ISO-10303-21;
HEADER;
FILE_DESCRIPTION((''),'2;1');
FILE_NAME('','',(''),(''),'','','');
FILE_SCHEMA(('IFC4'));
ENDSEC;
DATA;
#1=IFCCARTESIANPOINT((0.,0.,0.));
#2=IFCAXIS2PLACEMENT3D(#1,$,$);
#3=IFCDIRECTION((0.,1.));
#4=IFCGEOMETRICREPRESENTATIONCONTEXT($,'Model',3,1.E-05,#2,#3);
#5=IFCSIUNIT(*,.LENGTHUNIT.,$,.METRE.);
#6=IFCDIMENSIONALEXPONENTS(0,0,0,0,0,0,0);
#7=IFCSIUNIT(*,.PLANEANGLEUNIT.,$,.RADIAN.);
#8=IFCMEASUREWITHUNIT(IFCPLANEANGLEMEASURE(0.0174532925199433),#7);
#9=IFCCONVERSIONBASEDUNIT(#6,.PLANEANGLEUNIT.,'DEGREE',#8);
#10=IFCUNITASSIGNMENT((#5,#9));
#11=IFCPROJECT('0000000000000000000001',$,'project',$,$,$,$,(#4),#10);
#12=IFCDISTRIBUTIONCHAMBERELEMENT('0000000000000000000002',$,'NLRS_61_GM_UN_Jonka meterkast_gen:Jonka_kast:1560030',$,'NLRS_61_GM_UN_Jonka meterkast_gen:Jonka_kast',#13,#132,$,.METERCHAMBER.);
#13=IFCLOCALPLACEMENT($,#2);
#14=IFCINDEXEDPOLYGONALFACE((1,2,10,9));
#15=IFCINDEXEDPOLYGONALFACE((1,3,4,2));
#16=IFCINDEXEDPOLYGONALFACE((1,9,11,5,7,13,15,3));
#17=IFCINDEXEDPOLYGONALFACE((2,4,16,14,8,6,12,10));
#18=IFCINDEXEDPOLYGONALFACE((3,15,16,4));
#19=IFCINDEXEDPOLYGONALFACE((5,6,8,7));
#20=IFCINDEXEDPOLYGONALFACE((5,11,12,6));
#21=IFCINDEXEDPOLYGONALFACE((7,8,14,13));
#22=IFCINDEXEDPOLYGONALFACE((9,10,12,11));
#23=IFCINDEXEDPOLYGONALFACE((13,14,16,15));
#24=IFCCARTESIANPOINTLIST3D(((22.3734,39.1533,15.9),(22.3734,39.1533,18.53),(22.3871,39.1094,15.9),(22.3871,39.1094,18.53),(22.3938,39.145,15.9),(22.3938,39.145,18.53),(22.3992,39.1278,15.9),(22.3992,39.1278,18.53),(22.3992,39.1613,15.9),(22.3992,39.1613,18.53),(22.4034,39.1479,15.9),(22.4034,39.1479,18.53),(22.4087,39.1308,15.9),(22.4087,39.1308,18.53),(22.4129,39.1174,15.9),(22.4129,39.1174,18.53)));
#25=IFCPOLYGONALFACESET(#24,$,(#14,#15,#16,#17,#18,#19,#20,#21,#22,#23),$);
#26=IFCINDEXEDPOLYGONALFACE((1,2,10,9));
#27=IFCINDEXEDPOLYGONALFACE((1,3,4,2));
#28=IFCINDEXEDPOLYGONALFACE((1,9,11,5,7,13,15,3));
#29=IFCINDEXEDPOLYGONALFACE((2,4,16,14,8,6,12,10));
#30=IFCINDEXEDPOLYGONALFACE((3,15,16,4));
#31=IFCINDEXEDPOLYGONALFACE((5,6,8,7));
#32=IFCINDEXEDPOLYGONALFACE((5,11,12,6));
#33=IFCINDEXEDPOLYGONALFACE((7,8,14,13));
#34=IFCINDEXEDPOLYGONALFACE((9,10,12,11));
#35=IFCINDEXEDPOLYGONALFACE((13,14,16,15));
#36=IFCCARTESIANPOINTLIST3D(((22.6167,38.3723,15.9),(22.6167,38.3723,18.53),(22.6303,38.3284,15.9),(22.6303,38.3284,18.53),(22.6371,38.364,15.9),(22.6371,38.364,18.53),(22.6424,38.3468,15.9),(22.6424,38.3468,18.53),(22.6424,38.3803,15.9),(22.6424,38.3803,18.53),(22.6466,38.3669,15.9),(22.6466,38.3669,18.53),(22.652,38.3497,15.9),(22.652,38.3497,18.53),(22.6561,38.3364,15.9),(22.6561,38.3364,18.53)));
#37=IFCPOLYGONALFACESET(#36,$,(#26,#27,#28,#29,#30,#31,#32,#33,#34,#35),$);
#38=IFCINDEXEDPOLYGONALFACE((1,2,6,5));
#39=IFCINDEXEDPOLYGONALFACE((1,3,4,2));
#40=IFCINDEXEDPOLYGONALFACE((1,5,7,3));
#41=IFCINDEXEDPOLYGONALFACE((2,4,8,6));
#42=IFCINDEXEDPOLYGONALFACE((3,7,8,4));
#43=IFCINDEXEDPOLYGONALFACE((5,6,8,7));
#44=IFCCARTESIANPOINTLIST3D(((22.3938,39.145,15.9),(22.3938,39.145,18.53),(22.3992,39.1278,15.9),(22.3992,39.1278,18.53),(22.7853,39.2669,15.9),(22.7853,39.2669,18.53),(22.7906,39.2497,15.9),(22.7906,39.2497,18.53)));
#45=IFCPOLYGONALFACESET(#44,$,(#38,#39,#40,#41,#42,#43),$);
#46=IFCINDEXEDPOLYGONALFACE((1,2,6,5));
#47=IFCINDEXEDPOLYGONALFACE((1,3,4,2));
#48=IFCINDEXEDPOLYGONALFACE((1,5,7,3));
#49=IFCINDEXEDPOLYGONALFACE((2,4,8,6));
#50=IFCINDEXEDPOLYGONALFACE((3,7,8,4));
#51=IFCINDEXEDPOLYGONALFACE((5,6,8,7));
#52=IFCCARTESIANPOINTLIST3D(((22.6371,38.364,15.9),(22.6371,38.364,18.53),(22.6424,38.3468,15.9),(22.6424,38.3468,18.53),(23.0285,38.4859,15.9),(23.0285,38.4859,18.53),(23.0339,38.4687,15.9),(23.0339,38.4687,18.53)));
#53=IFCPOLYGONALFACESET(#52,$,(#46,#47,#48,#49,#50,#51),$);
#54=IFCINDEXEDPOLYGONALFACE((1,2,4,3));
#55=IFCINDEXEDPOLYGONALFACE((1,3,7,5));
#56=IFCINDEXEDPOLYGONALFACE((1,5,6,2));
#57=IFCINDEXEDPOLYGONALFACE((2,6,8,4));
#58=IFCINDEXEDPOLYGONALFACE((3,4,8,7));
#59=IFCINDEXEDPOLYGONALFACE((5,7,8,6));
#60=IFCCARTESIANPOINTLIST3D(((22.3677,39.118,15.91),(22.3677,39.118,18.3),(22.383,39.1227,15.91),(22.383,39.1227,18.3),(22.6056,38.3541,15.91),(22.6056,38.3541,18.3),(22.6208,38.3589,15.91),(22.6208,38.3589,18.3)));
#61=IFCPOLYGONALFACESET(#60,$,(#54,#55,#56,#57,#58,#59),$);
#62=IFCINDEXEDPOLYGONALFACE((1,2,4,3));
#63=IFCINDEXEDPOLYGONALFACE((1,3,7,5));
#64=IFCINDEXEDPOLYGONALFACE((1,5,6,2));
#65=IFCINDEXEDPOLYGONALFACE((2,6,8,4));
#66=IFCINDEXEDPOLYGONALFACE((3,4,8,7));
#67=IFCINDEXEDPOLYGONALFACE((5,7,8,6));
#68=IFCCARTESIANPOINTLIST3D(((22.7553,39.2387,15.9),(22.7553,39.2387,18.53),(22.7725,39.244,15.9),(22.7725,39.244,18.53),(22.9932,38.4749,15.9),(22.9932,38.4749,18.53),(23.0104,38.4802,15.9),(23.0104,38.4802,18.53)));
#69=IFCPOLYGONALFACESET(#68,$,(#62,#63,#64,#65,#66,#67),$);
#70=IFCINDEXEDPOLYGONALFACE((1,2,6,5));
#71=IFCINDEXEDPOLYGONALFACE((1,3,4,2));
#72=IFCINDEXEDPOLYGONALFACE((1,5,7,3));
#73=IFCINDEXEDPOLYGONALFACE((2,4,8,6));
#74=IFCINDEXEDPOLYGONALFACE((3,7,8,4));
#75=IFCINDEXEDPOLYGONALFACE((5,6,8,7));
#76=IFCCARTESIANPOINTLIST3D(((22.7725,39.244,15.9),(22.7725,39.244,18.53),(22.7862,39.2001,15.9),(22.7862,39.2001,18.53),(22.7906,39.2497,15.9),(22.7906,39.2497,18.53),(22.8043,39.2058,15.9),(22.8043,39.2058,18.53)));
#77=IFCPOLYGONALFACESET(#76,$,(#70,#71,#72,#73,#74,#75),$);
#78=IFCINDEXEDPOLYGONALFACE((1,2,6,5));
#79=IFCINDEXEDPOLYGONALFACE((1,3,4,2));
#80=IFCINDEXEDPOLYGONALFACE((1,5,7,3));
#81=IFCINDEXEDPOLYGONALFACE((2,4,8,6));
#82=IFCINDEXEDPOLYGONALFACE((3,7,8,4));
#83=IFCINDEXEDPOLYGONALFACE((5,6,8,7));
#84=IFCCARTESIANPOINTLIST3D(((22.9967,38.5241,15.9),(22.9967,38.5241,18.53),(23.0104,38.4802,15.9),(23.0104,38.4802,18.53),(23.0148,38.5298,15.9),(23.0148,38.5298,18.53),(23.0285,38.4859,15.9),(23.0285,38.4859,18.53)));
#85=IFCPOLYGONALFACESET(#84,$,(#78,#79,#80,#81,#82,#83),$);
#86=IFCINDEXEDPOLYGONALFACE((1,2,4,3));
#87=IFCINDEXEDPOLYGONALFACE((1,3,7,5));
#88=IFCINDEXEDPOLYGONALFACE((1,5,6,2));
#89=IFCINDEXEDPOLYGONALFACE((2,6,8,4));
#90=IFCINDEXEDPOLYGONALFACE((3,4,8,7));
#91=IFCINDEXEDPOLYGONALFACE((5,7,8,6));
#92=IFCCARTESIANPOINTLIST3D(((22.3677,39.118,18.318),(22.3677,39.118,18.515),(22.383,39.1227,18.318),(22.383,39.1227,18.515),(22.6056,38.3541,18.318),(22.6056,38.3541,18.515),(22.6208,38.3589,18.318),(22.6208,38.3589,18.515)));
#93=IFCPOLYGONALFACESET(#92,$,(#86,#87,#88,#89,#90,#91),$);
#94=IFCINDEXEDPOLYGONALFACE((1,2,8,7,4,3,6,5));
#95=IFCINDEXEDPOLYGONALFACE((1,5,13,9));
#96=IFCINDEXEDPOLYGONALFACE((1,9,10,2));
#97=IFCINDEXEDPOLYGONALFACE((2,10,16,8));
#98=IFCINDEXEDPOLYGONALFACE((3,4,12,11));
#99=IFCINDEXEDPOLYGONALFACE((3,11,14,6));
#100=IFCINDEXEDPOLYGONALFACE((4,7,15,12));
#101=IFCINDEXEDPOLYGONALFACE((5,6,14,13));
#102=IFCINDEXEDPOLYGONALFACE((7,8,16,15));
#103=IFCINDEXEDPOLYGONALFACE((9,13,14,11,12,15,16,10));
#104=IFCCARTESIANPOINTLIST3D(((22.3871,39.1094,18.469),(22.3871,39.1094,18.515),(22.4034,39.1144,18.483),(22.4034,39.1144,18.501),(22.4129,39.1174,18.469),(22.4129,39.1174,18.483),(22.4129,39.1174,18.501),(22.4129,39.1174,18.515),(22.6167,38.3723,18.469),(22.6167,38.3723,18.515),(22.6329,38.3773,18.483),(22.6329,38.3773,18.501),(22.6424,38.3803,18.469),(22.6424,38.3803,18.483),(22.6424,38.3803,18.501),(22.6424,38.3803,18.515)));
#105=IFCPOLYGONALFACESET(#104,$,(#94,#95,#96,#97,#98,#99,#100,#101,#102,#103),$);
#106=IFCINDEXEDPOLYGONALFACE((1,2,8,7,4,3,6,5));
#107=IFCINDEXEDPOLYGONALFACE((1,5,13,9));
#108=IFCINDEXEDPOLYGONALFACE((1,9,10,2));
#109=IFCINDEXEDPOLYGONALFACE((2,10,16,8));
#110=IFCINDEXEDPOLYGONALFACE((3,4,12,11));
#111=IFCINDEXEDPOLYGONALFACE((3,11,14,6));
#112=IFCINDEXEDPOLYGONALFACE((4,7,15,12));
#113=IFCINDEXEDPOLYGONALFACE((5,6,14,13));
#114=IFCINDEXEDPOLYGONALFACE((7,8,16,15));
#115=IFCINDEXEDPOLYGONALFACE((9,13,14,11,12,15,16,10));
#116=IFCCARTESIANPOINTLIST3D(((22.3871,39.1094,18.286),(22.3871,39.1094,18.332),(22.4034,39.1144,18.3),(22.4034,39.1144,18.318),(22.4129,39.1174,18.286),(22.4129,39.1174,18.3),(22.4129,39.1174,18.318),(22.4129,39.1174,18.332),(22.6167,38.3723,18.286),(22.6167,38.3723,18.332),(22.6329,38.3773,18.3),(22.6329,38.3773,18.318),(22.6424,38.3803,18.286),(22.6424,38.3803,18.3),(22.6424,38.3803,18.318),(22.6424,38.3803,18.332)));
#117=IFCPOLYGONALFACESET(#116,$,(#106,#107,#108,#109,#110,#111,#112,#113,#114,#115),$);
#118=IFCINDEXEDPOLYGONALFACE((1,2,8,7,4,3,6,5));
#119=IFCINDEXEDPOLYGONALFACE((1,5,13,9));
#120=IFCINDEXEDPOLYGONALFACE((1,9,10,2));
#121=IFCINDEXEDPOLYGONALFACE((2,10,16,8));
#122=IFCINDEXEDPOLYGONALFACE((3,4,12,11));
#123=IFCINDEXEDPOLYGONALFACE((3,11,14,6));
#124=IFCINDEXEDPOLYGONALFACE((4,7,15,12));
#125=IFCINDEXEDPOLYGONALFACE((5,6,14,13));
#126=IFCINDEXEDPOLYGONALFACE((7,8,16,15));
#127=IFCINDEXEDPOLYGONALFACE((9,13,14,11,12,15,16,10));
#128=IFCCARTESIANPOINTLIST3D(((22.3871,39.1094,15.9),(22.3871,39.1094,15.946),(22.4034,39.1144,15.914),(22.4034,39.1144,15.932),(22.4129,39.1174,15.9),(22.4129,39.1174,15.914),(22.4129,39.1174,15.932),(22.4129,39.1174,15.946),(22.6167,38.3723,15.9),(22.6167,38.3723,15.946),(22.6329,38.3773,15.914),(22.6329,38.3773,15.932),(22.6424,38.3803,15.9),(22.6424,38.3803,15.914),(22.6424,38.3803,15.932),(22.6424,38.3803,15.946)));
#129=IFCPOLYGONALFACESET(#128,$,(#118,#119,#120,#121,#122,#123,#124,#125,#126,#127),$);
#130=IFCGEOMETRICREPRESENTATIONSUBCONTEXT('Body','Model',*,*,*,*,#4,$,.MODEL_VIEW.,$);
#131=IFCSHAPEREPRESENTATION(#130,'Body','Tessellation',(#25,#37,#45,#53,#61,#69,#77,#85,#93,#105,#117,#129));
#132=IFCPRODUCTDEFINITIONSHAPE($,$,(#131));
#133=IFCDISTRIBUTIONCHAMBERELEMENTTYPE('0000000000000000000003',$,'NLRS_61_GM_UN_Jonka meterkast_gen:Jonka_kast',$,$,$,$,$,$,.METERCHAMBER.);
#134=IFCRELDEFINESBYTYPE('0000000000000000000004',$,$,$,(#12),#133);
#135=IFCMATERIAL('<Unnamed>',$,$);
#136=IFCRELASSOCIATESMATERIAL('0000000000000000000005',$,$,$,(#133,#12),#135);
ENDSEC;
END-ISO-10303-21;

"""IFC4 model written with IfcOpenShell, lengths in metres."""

from ifc_helpers import new_model, entity, si_unit, converted_unit, direction, frame, origin, place, context, subcontext, project, indexed_curve, outline, extrude, source, transform, mapped, material, type_object, type_shapes, element, save


model = new_model("IFC4")

# Units and contexts
model_context = context("Model", 3, precision=1e-05, world=origin(), true_north=direction((0.0, 1.0)))
body_context = subcontext(model_context, "Body", "Model", "MODEL_VIEW")
ifc_project = project(units=[si_unit("LENGTHUNIT", "METRE"), converted_unit("PLANEANGLEUNIT", "DEGREE", entity("IfcPlaneAngleMeasure", 0.0174532925199433), si_unit("PLANEANGLEUNIT", "RADIAN"), dimensions=[0, 0, 0, 0, 0, 0, 0])], contexts=[model_context])

# Distribution chamber element
ifc_material = material(Name="<Unnamed>")
distribution_chamber_element_type = type_object("IfcDistributionChamberElementType", Name="NLRS_61_GM_UN_Jonka meterkast_gen:Jonka_kast", PredefinedType="METERCHAMBER", material=ifc_material)
shared_shape_1 = source(origin(), body_context, "Body", "SweptSolid", [
    extrude(outline(indexed_curve([(-0.0093, -0.023), (0.0178, -0.023), (0.0178, 0.023), (-0.0093, 0.023), (-0.0093, 0.009), (0.0007, 0.009), (0.0007, -0.009), (-0.0093, -0.009), (-0.0093, -0.023)], self_intersect=False)), frame((-0.409, -0.4092, 0.0), z_axis=(0.0, 0.0, 1.0), x_axis=(0.0, -1.0, 0.0)), (0.0, 0.0, 1.0), 2.63),
    extrude(outline(indexed_curve([(-0.0093, -0.023), (0.0178, -0.023), (0.0178, 0.023), (-0.0093, 0.023), (-0.0093, 0.009), (0.0007, 0.009), (0.0007, -0.009), (-0.0093, -0.009), (-0.0093, -0.023)], self_intersect=False)), frame((0.409, -0.4092, 0.0), z_axis=(0.0, 0.0, 1.0), x_axis=(0.0, -1.0, 0.0)), (0.0, 0.0, 1.0), 2.63),
    extrude(outline(indexed_curve([(-0.205, -0.009), (0.205, -0.009), (0.205, 0.009), (-0.205, 0.009), (-0.205, -0.009)], self_intersect=False)), frame((-0.409, -0.205, 0.0), z_axis=(0.0, 0.0, 1.0), x_axis=(0.0, -1.0, 0.0)), (0.0, 0.0, 1.0), 2.63),
    extrude(outline(indexed_curve([(-0.205, -0.009), (0.205, -0.009), (0.205, 0.009), (-0.205, 0.009), (-0.205, -0.009)], self_intersect=False)), frame((0.409, -0.205, 0.0), z_axis=(0.0, 0.0, 1.0), x_axis=(0.0, -1.0, 0.0)), (0.0, 0.0, 1.0), 2.63),
    extrude(outline(indexed_curve([(-0.4, -0.008), (0.4, -0.008), (0.4, 0.008), (-0.4, 0.008), (-0.4, -0.008)], self_intersect=False)), frame((0.0, -0.435, 0.01), z_axis=(0.0, 0.0, 1.0), x_axis=(-1.0, 0.0, 0.0)), (0.0, 0.0, 1.0), 2.39),
    extrude(outline(indexed_curve([(-0.4, -0.009), (0.4, -0.009), (0.4, 0.009), (-0.4, 0.009), (-0.4, -0.009)], self_intersect=False)), frame((0.0, -0.028, 0.0), z_axis=(0.0, 0.0, 1.0), x_axis=(-1.0, 0.0, 0.0)), (0.0, 0.0, 1.0), 2.63),
    extrude(outline(indexed_curve([(-0.023, -0.0095), (0.023, -0.0095), (0.023, 0.0095), (-0.023, 0.0095), (-0.023, -0.0095)], self_intersect=False)), frame((-0.377, -0.0095, 0.0), z_axis=(0.0, 0.0, 1.0), x_axis=(-1.0, 0.0, 0.0)), (0.0, 0.0, 1.0), 2.63),
    extrude(outline(indexed_curve([(-0.023, -0.0095), (0.023, -0.0095), (0.023, 0.0095), (-0.023, 0.0095), (-0.023, -0.0095)], self_intersect=False)), frame((0.377, -0.0095, 0.0), z_axis=(0.0, 0.0, 1.0), x_axis=(-1.0, 0.0, 0.0)), (0.0, 0.0, 1.0), 2.63),
    extrude(outline(indexed_curve([(-0.4, -0.008), (0.4, -0.008), (0.4, 0.008), (-0.4, 0.008), (-0.4, -0.008)], self_intersect=False)), frame((0.0, -0.435, 2.418), z_axis=(0.0, 0.0, 1.0), x_axis=(-1.0, 0.0, 0.0)), (0.0, 0.0, 1.0), 0.197),
    extrude(outline(indexed_curve([(-0.023, -0.0178), (0.023, -0.0178), (0.023, 0.0093), (0.009, 0.0093), (0.009, -0.0007), (-0.009, -0.0007), (-0.009, 0.0093), (-0.023, 0.0093), (-0.023, -0.0178)], self_intersect=False)), frame((-0.386, -0.4092, 2.592), z_axis=(1.0, 0.0, 0.0), x_axis=(0.0, 0.0, -1.0)), (0.0, 0.0, 1.0), 0.772),
    extrude(outline(indexed_curve([(-0.023, -0.0178), (0.023, -0.0178), (0.023, 0.0093), (0.009, 0.0093), (0.009, -0.0007), (-0.009, -0.0007), (-0.009, 0.0093), (-0.023, 0.0093), (-0.023, -0.0178)], self_intersect=False)), frame((-0.386, -0.4092, 2.409), z_axis=(1.0, 0.0, 0.0), x_axis=(0.0, 0.0, -1.0)), (0.0, 0.0, 1.0), 0.772),
    extrude(outline(indexed_curve([(-0.023, -0.0178), (0.023, -0.0178), (0.023, 0.0093), (0.009, 0.0093), (0.009, -0.0007), (-0.009, -0.0007), (-0.009, 0.0093), (-0.023, 0.0093), (-0.023, -0.0178)], self_intersect=False)), frame((-0.386, -0.4092, 0.023), z_axis=(1.0, 0.0, 0.0), x_axis=(0.0, 0.0, -1.0)), (0.0, 0.0, 1.0), 0.772),
])
type_shapes(distribution_chamber_element_type, [shared_shape_1])
placement_1 = place(None, frame((13.1348, 11.9886, 0.0), z_axis=(0.0, 0.0, 1.0), x_axis=(0.954771, 0.297342, 0.0)))
placement_2 = place(placement_1, origin())
placement_3 = place(placement_2, frame((0.0, 0.0, 15.9)))
placement_4 = place(placement_3, origin())
distribution_chamber_element_1_placement = place(placement_4, frame((17.325, 22.757, 0.0), z_axis=(0.0, 0.0, 1.0), x_axis=(0.0, -1.0, 0.0)))
element("IfcDistributionChamberElement", 1, at=distribution_chamber_element_1_placement, type_object=distribution_chamber_element_type, material=ifc_material, Name="NLRS_61_GM_UN_Jonka meterkast_gen:Jonka_kast:1560030", ObjectType="NLRS_61_GM_UN_Jonka meterkast_gen:Jonka_kast", PredefinedType="METERCHAMBER", context=body_context, shape_type="MappedRepresentation", body=[
    mapped(shared_shape_1, transform((0.0, 0.0, 0.0), scale=1.0)),
])

save(model, "model.ifc")
